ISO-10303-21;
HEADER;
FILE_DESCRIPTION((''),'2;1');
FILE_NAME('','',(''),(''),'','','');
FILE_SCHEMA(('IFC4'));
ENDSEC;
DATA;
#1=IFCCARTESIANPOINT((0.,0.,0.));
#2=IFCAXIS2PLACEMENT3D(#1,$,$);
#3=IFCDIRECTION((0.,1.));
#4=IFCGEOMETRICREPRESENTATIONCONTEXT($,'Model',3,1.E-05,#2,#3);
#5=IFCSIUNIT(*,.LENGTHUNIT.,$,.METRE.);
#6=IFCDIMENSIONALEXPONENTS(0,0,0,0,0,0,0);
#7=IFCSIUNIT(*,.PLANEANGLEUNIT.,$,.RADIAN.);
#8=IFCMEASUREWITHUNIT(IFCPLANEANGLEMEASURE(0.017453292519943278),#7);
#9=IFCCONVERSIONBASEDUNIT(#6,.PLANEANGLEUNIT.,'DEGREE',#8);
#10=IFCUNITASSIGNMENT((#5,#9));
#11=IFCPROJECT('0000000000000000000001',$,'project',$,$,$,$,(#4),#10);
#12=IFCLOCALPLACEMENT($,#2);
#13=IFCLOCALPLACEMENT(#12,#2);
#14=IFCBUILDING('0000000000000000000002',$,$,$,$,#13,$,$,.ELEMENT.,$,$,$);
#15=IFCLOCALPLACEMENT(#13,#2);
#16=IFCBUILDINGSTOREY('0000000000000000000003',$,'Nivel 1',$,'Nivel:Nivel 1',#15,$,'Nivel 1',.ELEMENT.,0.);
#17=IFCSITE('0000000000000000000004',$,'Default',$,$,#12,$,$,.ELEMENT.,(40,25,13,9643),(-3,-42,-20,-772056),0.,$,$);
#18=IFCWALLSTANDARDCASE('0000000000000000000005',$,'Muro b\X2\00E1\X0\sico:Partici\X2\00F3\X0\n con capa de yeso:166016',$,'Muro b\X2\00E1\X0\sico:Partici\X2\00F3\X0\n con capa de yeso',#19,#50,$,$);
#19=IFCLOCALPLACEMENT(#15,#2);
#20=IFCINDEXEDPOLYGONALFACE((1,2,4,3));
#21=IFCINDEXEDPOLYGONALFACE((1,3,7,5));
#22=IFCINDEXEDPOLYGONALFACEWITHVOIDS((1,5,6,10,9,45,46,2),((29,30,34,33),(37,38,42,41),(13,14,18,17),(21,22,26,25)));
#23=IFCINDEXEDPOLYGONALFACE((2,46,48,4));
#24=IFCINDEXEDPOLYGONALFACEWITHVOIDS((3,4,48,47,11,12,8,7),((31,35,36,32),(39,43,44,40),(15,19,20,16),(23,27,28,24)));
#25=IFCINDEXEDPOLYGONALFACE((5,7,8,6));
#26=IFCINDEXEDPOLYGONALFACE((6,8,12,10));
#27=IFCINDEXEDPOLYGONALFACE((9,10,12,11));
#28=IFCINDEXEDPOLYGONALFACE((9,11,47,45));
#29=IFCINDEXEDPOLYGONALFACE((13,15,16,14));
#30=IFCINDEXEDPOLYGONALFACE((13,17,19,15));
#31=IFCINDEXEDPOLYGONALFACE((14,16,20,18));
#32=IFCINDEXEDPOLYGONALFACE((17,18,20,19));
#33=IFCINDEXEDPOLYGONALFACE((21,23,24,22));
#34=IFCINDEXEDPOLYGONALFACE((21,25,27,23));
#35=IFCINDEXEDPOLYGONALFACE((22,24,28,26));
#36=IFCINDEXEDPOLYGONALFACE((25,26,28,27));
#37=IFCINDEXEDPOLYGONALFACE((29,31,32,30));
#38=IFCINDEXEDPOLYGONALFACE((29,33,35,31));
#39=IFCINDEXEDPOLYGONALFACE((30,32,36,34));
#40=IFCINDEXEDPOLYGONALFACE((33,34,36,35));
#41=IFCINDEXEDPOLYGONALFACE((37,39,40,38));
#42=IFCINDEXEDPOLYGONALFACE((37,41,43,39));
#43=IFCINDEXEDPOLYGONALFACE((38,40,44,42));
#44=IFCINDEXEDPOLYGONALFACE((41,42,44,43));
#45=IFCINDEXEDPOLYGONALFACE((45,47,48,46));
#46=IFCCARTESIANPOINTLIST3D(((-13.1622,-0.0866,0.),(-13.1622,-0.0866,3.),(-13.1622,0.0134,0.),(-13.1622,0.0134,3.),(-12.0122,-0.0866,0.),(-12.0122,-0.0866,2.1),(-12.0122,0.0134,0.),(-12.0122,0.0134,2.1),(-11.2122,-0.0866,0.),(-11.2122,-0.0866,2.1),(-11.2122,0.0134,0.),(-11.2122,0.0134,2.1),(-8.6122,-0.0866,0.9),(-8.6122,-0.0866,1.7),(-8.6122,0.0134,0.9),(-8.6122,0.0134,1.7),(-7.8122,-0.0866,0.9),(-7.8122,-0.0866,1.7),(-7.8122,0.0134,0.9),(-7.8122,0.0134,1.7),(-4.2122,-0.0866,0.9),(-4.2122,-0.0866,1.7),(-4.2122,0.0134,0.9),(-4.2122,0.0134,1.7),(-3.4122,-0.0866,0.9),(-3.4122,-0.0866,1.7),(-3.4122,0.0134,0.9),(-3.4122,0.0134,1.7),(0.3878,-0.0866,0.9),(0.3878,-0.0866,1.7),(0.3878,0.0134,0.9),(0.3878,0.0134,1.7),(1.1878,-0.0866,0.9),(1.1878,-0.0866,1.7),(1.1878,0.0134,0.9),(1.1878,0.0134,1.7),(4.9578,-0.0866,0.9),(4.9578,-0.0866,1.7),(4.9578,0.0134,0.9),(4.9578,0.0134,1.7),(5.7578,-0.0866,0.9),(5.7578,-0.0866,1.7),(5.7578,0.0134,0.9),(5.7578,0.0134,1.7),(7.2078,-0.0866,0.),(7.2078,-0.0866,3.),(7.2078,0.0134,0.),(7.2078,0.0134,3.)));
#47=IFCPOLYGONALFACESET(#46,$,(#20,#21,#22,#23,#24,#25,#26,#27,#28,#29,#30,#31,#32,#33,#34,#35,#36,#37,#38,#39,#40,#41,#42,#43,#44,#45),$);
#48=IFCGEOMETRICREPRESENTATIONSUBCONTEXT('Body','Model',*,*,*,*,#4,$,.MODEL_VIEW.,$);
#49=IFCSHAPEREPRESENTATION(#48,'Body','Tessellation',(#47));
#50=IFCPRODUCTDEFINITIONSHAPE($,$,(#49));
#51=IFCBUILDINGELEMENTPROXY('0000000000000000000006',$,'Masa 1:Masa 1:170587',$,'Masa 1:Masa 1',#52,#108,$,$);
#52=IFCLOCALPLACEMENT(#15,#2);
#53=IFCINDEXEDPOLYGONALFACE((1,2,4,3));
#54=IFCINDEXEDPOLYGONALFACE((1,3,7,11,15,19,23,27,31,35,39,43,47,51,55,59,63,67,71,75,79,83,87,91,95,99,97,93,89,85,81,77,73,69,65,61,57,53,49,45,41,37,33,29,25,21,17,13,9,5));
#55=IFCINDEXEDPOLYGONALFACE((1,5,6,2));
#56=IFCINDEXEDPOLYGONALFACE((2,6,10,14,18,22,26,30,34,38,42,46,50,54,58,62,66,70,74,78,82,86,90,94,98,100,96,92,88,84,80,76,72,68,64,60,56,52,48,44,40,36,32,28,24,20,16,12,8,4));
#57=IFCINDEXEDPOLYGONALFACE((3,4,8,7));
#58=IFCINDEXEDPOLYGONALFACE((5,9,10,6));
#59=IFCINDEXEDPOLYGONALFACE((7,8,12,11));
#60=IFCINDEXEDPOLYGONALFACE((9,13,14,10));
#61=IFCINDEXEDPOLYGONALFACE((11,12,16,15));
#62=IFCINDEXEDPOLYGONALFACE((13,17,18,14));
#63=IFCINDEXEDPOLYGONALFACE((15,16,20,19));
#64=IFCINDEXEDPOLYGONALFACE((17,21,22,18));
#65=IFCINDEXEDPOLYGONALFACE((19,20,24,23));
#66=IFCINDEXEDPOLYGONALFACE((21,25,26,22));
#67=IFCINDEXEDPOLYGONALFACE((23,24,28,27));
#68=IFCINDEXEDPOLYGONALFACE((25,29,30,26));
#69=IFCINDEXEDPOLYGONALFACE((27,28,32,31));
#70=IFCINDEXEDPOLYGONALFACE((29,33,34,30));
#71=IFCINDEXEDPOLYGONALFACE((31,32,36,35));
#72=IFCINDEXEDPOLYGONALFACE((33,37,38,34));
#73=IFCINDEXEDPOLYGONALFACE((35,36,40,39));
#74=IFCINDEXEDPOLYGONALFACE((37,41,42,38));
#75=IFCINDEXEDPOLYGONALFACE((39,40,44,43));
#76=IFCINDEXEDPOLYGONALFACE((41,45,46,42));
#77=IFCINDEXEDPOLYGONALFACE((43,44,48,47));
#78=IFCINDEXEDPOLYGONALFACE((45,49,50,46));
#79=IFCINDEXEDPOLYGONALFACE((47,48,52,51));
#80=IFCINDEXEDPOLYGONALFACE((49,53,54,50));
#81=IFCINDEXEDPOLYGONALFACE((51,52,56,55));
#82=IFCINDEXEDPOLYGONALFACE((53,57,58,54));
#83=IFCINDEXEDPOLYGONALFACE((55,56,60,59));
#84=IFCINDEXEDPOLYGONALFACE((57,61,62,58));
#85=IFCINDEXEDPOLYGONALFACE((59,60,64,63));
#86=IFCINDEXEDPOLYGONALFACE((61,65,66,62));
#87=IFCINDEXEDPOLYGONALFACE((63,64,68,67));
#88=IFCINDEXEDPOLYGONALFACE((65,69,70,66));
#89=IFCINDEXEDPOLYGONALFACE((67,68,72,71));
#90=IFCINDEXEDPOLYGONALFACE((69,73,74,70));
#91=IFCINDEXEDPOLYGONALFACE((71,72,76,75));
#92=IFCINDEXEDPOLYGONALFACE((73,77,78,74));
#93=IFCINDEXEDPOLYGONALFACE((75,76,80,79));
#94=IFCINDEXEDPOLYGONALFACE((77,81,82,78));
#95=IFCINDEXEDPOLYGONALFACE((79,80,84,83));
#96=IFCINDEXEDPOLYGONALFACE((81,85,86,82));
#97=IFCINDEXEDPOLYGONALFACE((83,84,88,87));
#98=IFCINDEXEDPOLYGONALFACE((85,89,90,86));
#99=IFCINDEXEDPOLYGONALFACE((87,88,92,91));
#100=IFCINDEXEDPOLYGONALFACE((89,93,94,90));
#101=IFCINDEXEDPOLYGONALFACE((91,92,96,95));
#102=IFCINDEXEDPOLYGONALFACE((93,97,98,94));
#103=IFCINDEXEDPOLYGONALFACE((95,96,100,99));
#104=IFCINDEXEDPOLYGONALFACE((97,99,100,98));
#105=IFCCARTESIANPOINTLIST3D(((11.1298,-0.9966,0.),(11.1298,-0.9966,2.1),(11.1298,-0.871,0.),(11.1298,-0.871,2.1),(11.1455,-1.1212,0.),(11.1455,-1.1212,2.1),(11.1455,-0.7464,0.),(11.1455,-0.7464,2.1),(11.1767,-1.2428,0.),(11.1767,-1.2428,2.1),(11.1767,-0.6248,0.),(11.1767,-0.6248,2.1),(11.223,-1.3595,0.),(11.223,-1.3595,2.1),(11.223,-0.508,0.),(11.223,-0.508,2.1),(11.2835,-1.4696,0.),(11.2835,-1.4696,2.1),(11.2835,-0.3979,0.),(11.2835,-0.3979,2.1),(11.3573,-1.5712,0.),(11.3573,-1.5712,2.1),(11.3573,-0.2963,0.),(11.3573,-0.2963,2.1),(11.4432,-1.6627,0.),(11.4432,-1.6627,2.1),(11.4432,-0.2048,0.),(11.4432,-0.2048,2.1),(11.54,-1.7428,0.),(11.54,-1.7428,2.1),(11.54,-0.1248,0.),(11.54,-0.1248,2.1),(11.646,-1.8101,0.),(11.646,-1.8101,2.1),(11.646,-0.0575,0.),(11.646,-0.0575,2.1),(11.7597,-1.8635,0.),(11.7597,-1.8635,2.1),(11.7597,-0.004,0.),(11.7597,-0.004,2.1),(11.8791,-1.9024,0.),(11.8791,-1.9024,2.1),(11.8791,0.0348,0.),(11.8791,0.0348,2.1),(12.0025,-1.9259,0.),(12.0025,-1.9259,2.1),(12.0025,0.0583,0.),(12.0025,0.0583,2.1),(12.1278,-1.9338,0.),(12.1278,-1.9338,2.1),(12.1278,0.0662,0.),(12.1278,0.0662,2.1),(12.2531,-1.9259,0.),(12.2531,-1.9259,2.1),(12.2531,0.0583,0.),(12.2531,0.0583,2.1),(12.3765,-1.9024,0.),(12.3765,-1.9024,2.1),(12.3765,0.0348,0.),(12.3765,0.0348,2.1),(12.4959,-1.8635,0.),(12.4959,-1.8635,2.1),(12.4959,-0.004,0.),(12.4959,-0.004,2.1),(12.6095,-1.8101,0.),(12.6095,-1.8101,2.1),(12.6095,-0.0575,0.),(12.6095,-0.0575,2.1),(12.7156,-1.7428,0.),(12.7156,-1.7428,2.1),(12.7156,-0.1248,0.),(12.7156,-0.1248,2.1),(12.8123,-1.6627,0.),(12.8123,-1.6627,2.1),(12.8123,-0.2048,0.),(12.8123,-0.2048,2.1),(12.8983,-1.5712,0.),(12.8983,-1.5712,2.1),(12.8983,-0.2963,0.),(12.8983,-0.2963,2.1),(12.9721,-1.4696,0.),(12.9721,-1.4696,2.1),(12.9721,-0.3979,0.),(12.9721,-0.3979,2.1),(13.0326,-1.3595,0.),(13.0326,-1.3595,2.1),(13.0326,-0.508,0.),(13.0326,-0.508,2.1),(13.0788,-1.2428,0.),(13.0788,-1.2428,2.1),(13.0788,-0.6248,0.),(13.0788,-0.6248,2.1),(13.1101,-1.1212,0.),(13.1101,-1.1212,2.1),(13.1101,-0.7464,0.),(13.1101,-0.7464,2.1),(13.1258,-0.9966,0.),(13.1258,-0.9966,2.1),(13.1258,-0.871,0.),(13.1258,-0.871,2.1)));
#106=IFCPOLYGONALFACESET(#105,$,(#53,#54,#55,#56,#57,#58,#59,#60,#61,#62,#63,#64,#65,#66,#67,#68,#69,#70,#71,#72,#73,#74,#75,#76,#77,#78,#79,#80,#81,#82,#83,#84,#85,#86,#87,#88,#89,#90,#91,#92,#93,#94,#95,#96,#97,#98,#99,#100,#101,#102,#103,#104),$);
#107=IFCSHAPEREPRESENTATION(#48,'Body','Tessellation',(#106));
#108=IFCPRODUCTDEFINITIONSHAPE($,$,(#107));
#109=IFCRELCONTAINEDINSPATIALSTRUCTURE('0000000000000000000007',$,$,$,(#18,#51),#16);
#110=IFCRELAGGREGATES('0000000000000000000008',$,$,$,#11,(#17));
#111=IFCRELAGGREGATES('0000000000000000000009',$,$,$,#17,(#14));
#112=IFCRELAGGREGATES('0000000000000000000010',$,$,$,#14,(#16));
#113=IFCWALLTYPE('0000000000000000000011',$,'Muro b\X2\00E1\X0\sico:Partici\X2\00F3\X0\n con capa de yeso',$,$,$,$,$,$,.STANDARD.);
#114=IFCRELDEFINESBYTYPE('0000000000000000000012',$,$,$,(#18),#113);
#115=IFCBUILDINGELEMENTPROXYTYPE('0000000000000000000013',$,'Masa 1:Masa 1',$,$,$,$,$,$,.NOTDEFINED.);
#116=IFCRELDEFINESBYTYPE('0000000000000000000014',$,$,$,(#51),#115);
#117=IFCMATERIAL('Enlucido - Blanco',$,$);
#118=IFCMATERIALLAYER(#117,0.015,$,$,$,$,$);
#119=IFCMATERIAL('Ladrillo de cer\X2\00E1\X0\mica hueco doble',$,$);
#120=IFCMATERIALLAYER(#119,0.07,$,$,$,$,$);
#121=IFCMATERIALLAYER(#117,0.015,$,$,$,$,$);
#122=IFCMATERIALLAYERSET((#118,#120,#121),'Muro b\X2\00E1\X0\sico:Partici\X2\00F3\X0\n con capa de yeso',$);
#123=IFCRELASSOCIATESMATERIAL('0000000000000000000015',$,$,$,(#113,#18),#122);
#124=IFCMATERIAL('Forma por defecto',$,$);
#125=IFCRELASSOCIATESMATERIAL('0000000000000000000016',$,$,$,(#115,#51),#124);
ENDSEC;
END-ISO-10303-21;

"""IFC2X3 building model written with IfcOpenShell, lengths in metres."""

from ifc_helpers import new_model, entity, si_unit, converted_unit, direction, frame, frame_2d, origin, place, context, subcontext, project, spatial, rectangle, circle, extrude, source, transform, mapped, material, layer, layer_set, layer_usage, type_object, type_shapes, element, save


model = new_model("IFC2X3")

# Units and contexts
model_context = context("Model", 3, precision=1e-05, world=origin(), true_north=direction((0.0, 1.0)))
body_context = subcontext(model_context, "Body", "Model", "MODEL_VIEW")
ifc_project = project(units=[si_unit("LENGTHUNIT", "METRE"), converted_unit("PLANEANGLEUNIT", "DEGREE", entity("IfcPlaneAngleMeasure", 0.017453292519943278), si_unit("PLANEANGLEUNIT", "RADIAN"), dimensions=[0, 0, 0, 0, 0, 0, 0])], contexts=[model_context])

# Site, building, storey
site_placement = place(None, origin())
site = spatial("IfcSite", under=ifc_project, at=site_placement, Name="Default", CompositionType="ELEMENT", RefLatitude=(40, 25, 13, 9643), RefLongitude=(-3, -42, -20, -772056), RefElevation=0.0)
building_placement = place(site_placement, origin())
building = spatial("IfcBuilding", under=site, at=building_placement, CompositionType="ELEMENT")
storey_placement = place(building_placement, origin())
storey = spatial("IfcBuildingStorey", under=building, at=storey_placement, Name="Nivel 1", ObjectType="Nivel:Nivel 1", LongName="Nivel 1", CompositionType="ELEMENT", Elevation=0.0)

# Shared definitions
ifc_material_1 = material(Name="Enlucido - Blanco")
ifc_layer_1 = layer(ifc_material_1, 0.015)
ifc_material_2 = material(Name="Ladrillo de cerámica hueco doble")
ifc_layer_2 = layer(ifc_material_2, 0.07)
ifc_layer_3 = layer(ifc_material_1, 0.015)
ifc_layer_set_1 = layer_set([ifc_layer_1, ifc_layer_2, ifc_layer_3], Name="Muro básico:Partición con capa de yeso")
wall_type = type_object("IfcWallType", Name="Muro básico:Partición con capa de yeso", PredefinedType="STANDARD", material=ifc_layer_set_1)

# Wall, openings
ifc_layer_usage_1 = layer_usage(ifc_layer_set_1, "AXIS2", "NEGATIVE", 0.05)
wall_1_placement = place(storey_placement, frame((7.2078, -0.0366, 0.0), z_axis=(0.0, 0.0, 1.0), x_axis=(-1.0, 0.0, 0.0)))
wall_1 = element("IfcWallStandardCase", 1, at=wall_1_placement, inside=storey, type_object=wall_type, material=ifc_layer_usage_1, Name="Muro básico:Partición con capa de yeso:166016", ObjectType="Muro básico:Partición con capa de yeso", context=body_context, shape_type="SweptSolid", body=[
    extrude(rectangle(XDim=20.37, YDim=0.1, at=frame_2d((10.185, 0.0), x_axis=(-1.0, 0.0))), origin(), (0.0, 0.0, 1.0), 3.0),
])
opening_1_placement = place(wall_1_placement, frame((19.22, 0.05, 0.0)))
element("IfcOpeningElement", 2, at=opening_1_placement, cuts=wall_1, ObjectType="Opening", context=body_context, shape_type="SweptSolid", body=[
    extrude(rectangle(XDim=2.1, YDim=0.8, at=frame_2d((1.05, 0.4), x_axis=(1.0, 0.0))), frame((0.0, 0.0, 0.0), z_axis=(0.0, -1.0, 0.0), x_axis=(0.0, 0.0, 1.0)), (0.0, 0.0, 1.0), 0.1),
])
opening_2_placement = place(wall_1_placement, frame((15.82, 0.05, 0.9)))
element("IfcOpeningElement", 3, at=opening_2_placement, cuts=wall_1, ObjectType="Opening", context=body_context, shape_type="SweptSolid", body=[
    extrude(rectangle(XDim=0.8, YDim=0.8, at=frame_2d((0.4, 0.4), x_axis=(1.0, 0.0))), frame((0.0, 0.0, 0.0), z_axis=(0.0, -1.0, 0.0), x_axis=(0.0, 0.0, 1.0)), (0.0, 0.0, 1.0), 0.1),
])
opening_3_placement = place(wall_1_placement, frame((10.62, -0.05, 0.9)))
element("IfcOpeningElement", 4, at=opening_3_placement, cuts=wall_1, ObjectType="Opening", context=body_context, shape_type="SweptSolid", body=[
    extrude(rectangle(XDim=0.8, YDim=0.8, at=frame_2d((0.4, 0.4), x_axis=(1.0, 0.0))), frame((0.0, 0.0, 0.0), z_axis=(0.0, 1.0, 0.0), x_axis=(0.0, 0.0, 1.0)), (0.0, 0.0, 1.0), 0.1),
])
opening_4_placement = place(wall_1_placement, frame((6.02, -0.05, 0.9)))
element("IfcOpeningElement", 5, at=opening_4_placement, cuts=wall_1, ObjectType="Opening", context=body_context, shape_type="SweptSolid", body=[
    extrude(rectangle(XDim=0.8, YDim=0.8, at=frame_2d((0.4, 0.4), x_axis=(1.0, 0.0))), frame((0.0, 0.0, 0.0), z_axis=(0.0, 1.0, 0.0), x_axis=(0.0, 0.0, 1.0)), (0.0, 0.0, 1.0), 0.1),
])
opening_5_placement = place(wall_1_placement, frame((1.45, -0.05, 0.9)))
element("IfcOpeningElement", 6, at=opening_5_placement, cuts=wall_1, ObjectType="Opening", context=body_context, shape_type="SweptSolid", body=[
    extrude(rectangle(XDim=0.8, YDim=0.8, at=frame_2d((0.4, 0.4), x_axis=(1.0, 0.0))), frame((0.0, 0.0, 0.0), z_axis=(0.0, 1.0, 0.0), x_axis=(0.0, 0.0, 1.0)), (0.0, 0.0, 1.0), 0.1),
])

# Building element proxy
ifc_material_3 = material(Name="Forma por defecto")
building_element_proxy_type = type_object("IfcBuildingElementProxyType", Name="Masa 1:Masa 1", PredefinedType="NOTDEFINED", material=ifc_material_3)
shared_shape_1 = source(origin(), body_context, "Body", "SweptSolid", [
    extrude(circle(Radius=1.0, at=frame_2d((0.0, 0.0), x_axis=(1.0, 0.0))), frame((12.1278, -0.9338, 0.0), z_axis=(0.0, 0.0, 1.0), x_axis=(0.0, -1.0, 0.0)), (0.0, 0.0, 1.0), 2.1),
])
type_shapes(building_element_proxy_type, [shared_shape_1])
proxy_placement = place(storey_placement, origin())
element("IfcBuildingElementProxy", 7, at=proxy_placement, inside=storey, type_object=building_element_proxy_type, material=ifc_material_3, Name="Masa 1:Masa 1:170587", ObjectType="Masa 1:Masa 1", context=body_context, shape_type="MappedRepresentation", body=[
    mapped(shared_shape_1, transform((0.0, 0.0, 0.0), scale=1.0)),
])

save(model, "model.ifc")
